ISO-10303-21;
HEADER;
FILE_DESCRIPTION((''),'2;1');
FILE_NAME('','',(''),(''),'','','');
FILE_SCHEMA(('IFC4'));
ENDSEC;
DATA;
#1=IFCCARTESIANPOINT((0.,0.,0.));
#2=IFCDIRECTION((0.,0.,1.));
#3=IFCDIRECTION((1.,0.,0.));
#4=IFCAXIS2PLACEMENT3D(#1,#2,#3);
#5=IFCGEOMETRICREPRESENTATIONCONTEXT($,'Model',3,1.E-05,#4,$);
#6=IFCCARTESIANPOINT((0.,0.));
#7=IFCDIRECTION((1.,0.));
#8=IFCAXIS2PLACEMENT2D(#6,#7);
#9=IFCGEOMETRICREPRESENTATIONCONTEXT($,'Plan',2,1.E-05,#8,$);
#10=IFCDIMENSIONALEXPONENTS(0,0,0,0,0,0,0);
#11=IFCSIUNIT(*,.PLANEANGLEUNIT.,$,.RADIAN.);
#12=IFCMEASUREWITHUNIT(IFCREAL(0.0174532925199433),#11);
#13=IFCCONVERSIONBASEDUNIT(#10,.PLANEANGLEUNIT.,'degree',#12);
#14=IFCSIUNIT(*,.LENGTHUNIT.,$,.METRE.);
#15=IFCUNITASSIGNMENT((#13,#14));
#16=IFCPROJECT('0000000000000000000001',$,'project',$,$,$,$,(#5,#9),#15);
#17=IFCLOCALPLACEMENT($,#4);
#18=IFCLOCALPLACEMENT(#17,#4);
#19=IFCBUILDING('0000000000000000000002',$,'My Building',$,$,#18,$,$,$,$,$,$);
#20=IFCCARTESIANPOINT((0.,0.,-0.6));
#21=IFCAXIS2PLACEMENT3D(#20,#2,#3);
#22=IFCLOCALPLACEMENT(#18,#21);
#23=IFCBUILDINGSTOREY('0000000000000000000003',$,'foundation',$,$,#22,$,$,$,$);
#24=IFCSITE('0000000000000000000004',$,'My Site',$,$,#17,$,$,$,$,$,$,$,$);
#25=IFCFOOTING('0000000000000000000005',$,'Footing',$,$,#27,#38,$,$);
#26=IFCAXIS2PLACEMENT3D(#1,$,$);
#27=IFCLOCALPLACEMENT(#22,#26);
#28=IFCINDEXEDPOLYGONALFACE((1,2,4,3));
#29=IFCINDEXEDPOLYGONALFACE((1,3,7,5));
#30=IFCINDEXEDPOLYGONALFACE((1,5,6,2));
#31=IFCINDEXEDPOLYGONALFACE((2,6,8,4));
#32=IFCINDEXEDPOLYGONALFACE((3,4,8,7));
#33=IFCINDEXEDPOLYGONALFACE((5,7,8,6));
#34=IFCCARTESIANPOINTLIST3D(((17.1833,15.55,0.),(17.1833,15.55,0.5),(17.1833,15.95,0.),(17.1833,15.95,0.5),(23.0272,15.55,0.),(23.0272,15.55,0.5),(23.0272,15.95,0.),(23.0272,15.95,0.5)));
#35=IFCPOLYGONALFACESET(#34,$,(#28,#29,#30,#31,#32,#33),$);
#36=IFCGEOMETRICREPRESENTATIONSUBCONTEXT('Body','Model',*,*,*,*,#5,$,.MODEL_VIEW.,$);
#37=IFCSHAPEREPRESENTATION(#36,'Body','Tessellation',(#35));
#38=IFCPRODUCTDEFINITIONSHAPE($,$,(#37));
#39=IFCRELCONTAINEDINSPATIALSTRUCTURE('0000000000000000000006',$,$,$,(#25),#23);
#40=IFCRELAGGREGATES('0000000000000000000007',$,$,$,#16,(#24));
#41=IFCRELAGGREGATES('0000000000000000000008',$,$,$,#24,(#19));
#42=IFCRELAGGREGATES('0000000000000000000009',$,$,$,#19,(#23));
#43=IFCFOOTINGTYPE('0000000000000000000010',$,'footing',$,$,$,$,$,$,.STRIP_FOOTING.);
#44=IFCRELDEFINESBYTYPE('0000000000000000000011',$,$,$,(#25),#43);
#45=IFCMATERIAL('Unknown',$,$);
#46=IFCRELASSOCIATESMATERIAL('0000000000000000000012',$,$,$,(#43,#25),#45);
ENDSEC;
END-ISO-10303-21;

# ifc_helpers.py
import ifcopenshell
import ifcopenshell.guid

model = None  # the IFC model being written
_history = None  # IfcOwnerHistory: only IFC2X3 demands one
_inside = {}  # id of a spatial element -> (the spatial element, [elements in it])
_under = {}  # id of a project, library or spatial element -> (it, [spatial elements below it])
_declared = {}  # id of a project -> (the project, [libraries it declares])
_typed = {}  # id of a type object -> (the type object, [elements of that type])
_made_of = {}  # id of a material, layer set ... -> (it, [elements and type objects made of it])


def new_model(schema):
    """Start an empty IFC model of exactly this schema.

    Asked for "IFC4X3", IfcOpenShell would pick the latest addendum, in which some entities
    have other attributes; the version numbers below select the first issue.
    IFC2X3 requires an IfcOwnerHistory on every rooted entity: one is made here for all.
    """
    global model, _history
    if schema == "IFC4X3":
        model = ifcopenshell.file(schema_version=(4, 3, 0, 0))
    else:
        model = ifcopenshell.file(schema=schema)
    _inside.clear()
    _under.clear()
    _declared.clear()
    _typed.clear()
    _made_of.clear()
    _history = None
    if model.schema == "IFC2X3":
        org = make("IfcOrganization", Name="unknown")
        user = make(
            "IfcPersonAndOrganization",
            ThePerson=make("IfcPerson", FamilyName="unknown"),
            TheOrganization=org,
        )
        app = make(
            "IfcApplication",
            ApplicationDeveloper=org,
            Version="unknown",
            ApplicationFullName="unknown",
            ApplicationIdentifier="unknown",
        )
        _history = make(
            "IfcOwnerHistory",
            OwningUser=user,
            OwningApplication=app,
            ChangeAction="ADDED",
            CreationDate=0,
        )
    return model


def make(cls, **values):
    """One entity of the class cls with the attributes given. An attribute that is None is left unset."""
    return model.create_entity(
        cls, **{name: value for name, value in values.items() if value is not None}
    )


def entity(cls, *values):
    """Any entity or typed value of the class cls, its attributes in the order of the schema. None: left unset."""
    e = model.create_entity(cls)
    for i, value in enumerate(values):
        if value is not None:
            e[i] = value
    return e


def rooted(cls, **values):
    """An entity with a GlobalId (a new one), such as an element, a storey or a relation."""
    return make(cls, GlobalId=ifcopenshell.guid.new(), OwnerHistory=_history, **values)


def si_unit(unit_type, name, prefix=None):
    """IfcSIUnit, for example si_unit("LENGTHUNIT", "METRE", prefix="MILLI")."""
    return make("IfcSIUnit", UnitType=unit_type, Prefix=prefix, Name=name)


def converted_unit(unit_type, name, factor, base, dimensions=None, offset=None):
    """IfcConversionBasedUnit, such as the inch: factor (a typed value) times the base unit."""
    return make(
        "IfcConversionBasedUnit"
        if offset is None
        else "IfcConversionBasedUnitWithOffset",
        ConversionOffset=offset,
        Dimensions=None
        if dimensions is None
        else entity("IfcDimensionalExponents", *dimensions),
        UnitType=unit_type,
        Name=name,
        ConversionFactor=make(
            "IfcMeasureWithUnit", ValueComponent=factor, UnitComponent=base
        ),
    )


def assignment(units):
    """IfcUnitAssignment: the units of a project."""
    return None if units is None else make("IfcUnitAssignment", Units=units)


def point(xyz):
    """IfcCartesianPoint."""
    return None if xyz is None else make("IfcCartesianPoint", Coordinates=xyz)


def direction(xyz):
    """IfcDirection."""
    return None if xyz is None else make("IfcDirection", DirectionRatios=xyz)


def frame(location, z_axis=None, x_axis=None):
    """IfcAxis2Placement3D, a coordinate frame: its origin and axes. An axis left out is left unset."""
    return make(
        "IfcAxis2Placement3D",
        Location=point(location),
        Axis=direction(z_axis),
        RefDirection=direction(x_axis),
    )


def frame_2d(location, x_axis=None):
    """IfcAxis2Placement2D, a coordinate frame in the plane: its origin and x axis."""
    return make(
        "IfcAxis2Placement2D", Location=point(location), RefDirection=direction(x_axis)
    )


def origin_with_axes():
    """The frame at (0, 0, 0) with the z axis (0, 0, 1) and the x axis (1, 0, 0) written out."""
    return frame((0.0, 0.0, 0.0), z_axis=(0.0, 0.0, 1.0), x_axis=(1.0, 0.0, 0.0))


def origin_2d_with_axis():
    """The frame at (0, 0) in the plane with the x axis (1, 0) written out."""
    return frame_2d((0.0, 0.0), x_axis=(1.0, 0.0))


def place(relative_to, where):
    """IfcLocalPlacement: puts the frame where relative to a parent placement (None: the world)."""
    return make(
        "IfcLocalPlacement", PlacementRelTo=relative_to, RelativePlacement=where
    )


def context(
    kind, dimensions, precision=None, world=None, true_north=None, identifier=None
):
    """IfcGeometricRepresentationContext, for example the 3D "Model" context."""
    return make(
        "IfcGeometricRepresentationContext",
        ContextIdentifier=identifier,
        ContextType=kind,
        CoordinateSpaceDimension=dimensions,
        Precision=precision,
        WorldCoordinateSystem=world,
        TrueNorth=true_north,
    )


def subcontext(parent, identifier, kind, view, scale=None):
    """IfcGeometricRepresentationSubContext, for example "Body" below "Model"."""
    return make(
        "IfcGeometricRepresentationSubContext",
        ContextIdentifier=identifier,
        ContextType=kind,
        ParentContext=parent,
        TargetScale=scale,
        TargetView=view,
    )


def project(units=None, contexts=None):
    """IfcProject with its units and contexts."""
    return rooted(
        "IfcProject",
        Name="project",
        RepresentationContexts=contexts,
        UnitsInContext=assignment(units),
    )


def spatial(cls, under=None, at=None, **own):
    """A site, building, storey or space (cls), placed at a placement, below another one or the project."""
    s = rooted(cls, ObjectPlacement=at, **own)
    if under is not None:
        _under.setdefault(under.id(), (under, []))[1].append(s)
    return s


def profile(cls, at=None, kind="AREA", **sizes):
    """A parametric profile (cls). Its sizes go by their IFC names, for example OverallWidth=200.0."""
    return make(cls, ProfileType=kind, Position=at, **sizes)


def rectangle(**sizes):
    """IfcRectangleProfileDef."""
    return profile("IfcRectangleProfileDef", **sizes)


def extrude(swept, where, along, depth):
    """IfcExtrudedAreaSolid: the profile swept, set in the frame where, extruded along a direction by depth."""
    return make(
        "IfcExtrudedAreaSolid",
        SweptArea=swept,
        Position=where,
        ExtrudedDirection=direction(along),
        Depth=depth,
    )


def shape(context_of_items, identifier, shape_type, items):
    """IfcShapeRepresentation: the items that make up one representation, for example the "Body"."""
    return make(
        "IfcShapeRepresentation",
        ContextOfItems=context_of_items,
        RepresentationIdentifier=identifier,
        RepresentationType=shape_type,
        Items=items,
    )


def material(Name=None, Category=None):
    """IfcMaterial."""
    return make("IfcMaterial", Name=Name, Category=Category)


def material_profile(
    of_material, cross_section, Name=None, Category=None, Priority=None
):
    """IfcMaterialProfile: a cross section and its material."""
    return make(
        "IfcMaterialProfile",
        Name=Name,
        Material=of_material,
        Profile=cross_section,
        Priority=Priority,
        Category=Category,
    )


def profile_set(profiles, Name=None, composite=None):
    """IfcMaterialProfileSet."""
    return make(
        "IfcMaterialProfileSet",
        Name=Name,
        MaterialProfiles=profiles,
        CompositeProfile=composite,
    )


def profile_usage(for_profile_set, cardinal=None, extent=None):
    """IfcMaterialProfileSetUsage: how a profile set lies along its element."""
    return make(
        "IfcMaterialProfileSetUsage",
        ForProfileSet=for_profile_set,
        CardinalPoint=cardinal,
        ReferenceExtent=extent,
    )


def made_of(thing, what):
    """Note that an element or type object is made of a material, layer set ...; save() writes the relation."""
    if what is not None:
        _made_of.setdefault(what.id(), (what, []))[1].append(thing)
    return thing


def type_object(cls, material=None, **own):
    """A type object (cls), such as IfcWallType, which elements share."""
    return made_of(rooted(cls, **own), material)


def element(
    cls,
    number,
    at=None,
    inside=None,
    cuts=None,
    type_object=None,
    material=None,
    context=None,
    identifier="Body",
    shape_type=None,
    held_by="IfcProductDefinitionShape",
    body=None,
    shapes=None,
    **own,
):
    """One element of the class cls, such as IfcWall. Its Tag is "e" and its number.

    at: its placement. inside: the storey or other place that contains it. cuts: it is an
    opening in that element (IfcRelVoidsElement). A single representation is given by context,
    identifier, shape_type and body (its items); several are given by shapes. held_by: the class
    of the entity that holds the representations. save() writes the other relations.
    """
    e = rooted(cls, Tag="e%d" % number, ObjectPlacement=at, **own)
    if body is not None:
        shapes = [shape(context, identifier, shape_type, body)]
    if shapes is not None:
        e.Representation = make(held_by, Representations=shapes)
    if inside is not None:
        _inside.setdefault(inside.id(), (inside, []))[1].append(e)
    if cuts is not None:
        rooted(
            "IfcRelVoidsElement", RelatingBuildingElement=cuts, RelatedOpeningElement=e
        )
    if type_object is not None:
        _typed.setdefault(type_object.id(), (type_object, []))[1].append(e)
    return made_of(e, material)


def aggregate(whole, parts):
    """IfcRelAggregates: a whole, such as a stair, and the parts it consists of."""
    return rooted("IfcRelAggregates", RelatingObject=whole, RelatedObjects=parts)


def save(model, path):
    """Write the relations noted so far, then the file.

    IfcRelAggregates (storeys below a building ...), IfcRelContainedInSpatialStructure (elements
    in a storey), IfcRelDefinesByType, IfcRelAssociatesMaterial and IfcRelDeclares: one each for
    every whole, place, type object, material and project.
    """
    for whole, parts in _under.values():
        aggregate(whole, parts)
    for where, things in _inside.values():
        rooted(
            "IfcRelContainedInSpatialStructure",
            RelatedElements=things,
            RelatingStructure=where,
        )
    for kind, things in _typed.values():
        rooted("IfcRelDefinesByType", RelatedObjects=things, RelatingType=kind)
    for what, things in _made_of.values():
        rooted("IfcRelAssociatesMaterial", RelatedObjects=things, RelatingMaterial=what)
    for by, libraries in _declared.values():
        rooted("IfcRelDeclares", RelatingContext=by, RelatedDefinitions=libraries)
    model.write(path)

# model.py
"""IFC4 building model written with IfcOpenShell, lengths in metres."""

from ifc_helpers import new_model, entity, si_unit, converted_unit, frame, origin_with_axes, origin_2d_with_axis, place, context, subcontext, project, spatial, rectangle, extrude, material, material_profile, profile_set, profile_usage, type_object, element, save


model = new_model("IFC4")

# Units and contexts
model_context = context("Model", 3, precision=1e-05, world=origin_with_axes())
plan_context = context("Plan", 2, precision=1e-05, world=origin_2d_with_axis())
body_context = subcontext(model_context, "Body", "Model", "MODEL_VIEW")
ifc_project = project(units=[converted_unit("PLANEANGLEUNIT", "degree", entity("IfcReal", 0.0174532925199433), si_unit("PLANEANGLEUNIT", "RADIAN"), dimensions=[0, 0, 0, 0, 0, 0, 0]), si_unit("LENGTHUNIT", "METRE")], contexts=[model_context, plan_context])

# Site, building, storey
site_placement = place(None, origin_with_axes())
site = spatial("IfcSite", under=ifc_project, at=site_placement, Name="My Site")
building_placement = place(site_placement, origin_with_axes())
building = spatial("IfcBuilding", under=site, at=building_placement, Name="My Building")
storey_placement = place(building_placement, frame((0.0, 0.0, -0.6), z_axis=(0.0, 0.0, 1.0), x_axis=(1.0, 0.0, 0.0)))
storey = spatial("IfcBuildingStorey", under=building, at=storey_placement, Name="foundation")

# Footing
ifc_material = material(Name="Unknown")
ifc_material_profile = material_profile(ifc_material, rectangle(XDim=0.4, YDim=0.5))
ifc_profile_set = profile_set([ifc_material_profile])
footing_type = type_object("IfcFootingType", Name="footing", PredefinedType="STRIP_FOOTING", material=ifc_profile_set)
ifc_profile_usage_1 = profile_usage(ifc_profile_set, cardinal=1)
footing_1_placement = place(storey_placement, frame((17.1833, 15.95, 0.0), z_axis=(1.0, 0.0, 0.0), x_axis=(0.0, 1.0, 0.0)))
element("IfcFooting", 1, at=footing_1_placement, inside=storey, type_object=footing_type, material=ifc_profile_usage_1, Name="Footing", context=body_context, shape_type="SweptSolid", body=[
    extrude(rectangle(XDim=0.4, YDim=0.5), frame((-0.2, 0.25, 0.0), z_axis=(0.0, 0.0, 1.0), x_axis=(1.0, 0.0, 0.0)), (0.0, 0.0, 1.0), 5.8439),
])

save(model, "model.ifc")
